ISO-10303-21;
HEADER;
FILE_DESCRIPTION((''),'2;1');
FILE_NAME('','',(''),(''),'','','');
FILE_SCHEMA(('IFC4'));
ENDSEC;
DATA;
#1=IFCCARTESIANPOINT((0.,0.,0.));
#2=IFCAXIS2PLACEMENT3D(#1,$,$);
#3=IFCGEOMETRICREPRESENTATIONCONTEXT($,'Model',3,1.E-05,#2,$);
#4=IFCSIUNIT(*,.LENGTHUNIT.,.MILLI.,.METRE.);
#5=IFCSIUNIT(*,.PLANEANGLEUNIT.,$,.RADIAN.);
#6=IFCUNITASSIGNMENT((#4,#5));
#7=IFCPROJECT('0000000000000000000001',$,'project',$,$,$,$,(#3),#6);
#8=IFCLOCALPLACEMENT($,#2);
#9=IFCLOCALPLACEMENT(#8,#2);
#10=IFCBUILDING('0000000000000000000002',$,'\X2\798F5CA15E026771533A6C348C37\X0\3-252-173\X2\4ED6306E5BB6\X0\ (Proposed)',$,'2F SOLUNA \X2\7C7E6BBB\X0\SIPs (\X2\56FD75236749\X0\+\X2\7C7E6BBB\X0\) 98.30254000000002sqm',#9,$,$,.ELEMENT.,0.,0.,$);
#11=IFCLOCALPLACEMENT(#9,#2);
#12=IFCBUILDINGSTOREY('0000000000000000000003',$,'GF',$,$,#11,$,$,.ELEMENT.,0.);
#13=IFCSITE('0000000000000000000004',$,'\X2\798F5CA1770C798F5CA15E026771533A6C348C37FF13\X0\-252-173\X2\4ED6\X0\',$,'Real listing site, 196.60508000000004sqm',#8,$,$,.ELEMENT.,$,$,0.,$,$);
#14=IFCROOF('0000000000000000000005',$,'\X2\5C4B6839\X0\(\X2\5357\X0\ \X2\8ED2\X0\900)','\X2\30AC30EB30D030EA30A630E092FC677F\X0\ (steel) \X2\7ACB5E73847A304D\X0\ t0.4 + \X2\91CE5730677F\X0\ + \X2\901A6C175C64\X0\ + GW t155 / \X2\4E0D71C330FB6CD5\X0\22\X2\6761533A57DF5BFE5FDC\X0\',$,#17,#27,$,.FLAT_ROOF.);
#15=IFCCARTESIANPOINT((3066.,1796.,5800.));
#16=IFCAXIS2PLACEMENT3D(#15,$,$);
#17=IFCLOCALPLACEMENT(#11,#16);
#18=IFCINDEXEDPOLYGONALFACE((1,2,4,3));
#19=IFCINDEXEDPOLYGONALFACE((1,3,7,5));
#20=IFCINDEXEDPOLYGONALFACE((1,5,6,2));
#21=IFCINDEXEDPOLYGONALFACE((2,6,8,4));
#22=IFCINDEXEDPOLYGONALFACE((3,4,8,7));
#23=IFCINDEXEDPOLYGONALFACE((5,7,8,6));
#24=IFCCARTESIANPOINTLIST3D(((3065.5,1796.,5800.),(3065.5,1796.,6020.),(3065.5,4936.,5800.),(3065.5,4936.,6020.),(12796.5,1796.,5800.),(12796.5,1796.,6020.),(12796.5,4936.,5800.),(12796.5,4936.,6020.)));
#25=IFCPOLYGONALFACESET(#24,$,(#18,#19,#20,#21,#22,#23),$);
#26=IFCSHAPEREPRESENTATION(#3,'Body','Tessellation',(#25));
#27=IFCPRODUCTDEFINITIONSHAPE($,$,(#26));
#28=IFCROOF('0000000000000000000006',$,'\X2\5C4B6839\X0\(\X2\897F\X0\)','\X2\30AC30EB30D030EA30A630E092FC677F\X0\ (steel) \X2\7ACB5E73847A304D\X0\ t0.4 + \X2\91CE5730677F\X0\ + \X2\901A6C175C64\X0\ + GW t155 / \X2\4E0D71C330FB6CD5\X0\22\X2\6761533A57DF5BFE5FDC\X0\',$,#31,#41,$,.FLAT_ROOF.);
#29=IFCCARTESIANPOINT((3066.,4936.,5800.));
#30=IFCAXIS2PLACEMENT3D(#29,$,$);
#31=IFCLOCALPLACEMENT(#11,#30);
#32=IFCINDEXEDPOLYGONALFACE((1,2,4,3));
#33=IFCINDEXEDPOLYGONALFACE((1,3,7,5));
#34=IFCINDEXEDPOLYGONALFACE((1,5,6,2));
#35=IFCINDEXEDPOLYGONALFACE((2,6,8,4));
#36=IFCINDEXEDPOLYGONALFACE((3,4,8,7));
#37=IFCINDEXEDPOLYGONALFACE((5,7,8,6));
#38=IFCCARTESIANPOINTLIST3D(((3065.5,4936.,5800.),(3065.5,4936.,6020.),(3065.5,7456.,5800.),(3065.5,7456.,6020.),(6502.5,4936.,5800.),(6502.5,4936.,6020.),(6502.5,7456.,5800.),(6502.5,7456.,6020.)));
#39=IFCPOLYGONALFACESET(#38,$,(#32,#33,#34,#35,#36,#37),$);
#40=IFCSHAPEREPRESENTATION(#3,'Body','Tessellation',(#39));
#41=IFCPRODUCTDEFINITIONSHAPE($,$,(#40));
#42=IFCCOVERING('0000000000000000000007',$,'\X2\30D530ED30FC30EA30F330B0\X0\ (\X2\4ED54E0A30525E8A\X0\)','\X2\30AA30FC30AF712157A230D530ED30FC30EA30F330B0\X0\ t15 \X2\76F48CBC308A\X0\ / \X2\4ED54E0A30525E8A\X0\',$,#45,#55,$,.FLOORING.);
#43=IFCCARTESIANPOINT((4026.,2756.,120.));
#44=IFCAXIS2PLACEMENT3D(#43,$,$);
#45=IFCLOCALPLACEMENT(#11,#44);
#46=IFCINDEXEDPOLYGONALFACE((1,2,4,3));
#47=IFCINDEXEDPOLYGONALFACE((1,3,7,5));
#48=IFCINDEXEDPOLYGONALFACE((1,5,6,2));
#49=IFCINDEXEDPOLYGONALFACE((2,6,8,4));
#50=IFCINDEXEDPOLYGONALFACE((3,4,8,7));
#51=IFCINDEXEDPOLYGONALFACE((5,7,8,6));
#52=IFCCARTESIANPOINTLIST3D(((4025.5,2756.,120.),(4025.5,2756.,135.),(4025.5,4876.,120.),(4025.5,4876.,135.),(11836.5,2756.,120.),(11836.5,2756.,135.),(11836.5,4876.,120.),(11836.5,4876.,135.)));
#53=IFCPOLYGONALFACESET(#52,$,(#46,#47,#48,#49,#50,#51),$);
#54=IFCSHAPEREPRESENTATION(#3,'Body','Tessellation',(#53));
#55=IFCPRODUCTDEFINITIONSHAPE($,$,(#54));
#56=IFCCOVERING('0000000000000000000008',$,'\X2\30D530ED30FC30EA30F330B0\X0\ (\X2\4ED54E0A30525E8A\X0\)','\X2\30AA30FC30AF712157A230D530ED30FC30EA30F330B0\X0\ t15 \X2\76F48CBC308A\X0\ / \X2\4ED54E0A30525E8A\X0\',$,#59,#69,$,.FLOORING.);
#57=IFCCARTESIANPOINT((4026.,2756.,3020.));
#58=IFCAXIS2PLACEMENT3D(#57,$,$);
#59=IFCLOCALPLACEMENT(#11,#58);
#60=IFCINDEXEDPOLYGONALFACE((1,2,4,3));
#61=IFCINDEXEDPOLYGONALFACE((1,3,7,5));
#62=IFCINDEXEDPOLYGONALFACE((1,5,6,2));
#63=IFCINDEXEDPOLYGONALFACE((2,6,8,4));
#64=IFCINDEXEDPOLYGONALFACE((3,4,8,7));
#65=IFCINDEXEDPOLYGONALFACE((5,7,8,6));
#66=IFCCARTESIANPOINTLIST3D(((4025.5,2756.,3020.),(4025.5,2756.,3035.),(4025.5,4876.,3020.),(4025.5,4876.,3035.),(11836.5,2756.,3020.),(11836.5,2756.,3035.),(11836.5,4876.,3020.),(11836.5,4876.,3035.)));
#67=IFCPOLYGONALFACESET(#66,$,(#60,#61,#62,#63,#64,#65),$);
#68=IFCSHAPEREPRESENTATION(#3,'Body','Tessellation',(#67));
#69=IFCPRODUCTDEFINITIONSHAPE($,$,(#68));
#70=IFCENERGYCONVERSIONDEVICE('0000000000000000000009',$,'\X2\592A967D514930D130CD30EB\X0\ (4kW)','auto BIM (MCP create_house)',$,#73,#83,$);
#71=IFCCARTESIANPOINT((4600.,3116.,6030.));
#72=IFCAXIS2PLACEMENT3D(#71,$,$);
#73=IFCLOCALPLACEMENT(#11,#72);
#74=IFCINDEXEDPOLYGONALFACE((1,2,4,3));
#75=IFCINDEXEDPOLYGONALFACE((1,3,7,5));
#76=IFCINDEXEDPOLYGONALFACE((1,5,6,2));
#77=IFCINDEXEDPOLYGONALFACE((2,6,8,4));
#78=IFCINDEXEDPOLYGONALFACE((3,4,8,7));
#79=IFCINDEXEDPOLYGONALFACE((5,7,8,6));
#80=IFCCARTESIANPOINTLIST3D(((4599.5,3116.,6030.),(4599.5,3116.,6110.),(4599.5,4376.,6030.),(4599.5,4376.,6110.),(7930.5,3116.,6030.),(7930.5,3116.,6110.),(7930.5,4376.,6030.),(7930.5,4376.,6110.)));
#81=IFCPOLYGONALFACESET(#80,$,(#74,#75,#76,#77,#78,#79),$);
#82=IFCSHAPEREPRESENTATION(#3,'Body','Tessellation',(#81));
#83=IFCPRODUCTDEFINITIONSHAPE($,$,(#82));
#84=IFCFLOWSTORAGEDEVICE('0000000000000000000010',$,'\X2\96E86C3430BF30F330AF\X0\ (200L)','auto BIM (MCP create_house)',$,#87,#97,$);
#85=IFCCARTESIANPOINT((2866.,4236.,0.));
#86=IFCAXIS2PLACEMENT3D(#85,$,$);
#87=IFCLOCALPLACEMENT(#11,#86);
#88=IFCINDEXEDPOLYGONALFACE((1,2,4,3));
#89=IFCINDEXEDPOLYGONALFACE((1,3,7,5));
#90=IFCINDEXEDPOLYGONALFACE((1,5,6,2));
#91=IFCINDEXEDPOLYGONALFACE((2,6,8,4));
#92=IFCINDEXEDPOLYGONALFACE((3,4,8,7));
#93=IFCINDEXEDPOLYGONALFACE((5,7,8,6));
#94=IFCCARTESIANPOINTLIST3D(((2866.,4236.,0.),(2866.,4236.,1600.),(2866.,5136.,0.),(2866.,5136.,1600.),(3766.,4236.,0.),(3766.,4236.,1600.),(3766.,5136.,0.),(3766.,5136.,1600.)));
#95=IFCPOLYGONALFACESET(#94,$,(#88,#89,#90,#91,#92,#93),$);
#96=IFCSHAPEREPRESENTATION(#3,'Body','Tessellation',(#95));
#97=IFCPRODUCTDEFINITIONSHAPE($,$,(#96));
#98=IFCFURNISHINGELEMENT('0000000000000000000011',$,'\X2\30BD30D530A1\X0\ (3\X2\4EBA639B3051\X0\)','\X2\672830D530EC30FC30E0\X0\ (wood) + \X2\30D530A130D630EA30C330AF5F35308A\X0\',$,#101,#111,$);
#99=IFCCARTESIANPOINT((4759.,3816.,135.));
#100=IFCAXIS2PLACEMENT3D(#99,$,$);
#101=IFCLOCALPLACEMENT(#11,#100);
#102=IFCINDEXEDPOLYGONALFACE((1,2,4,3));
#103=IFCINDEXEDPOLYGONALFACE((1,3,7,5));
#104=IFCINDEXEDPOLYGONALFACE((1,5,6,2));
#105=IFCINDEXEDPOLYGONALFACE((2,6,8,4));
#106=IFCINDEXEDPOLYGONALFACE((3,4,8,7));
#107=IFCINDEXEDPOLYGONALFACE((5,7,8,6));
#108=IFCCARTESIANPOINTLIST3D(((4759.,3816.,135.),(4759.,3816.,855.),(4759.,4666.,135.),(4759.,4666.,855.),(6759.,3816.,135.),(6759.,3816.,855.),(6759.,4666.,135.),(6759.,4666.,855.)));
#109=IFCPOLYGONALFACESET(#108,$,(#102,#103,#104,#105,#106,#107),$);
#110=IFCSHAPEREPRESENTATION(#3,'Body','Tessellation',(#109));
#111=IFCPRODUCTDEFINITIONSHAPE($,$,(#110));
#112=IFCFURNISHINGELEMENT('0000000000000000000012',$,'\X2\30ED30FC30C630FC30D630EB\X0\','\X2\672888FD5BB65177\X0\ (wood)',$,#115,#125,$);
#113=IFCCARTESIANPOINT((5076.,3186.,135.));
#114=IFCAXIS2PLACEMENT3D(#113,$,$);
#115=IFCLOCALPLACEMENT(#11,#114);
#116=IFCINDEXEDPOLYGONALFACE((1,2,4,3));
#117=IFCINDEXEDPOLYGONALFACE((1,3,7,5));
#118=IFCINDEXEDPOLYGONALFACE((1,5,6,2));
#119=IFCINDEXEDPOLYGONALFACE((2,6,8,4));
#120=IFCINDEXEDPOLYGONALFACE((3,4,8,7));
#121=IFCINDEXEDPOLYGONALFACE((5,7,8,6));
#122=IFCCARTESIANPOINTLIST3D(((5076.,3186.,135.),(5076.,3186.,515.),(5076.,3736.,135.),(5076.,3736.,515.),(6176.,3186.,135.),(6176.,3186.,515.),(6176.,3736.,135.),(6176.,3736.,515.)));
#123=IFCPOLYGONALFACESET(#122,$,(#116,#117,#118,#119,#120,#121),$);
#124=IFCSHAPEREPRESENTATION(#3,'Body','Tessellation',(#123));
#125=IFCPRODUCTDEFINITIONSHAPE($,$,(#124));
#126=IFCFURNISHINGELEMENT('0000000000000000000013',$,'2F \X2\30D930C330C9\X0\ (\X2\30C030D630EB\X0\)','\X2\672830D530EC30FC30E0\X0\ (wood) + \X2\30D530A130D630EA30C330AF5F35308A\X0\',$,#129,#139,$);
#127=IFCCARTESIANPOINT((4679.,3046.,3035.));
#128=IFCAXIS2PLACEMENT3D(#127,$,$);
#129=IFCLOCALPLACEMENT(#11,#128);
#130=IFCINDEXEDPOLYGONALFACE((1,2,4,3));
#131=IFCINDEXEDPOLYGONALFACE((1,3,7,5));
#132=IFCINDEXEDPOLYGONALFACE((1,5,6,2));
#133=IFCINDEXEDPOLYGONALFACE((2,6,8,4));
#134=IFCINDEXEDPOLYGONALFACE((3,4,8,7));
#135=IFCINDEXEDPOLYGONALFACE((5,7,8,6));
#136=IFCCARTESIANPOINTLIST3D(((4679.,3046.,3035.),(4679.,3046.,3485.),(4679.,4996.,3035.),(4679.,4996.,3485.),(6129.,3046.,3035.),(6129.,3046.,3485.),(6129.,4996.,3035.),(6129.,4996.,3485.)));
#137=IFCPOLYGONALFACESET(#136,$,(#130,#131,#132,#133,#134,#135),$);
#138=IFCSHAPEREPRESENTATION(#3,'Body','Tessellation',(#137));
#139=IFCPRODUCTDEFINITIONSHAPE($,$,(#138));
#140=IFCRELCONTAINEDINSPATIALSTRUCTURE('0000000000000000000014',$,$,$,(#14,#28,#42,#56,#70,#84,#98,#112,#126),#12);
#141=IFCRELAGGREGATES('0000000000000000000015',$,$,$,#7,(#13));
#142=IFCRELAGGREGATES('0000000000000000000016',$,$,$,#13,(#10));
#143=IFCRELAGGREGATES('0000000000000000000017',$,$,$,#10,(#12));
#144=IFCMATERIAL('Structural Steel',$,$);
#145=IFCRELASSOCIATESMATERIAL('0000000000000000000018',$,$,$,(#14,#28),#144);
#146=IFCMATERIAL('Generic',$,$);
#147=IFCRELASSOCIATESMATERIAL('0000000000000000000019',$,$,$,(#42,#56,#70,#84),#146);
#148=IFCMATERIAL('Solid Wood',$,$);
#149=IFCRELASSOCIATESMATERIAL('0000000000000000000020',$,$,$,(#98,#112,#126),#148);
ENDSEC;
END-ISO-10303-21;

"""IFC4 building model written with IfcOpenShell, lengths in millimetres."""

from ifc_helpers import new_model, si_unit, frame, frame_2d, origin, place, context, project, spatial, rectangle, extrude, material, element, save


model = new_model("IFC4")

# Units and contexts
model_context = context("Model", 3, precision=1e-05, world=origin())
ifc_project = project(units=[si_unit("LENGTHUNIT", "METRE", prefix="MILLI"), si_unit("PLANEANGLEUNIT", "RADIAN")], contexts=[model_context])

# Site, building, storey
site_placement = place(None, origin())
site = spatial("IfcSite", under=ifc_project, at=site_placement, Name="福岡県福岡市東区水谷３-252-173他", ObjectType="Real listing site, 196.60508000000004sqm", CompositionType="ELEMENT", RefElevation=0.0)
building_placement = place(site_placement, origin())
building = spatial("IfcBuilding", under=site, at=building_placement, Name="福岡市東区水谷3-252-173他の家 (Proposed)", ObjectType="2F SOLUNA 籾殻SIPs (国産杉+籾殻) 98.30254000000002sqm", CompositionType="ELEMENT", ElevationOfRefHeight=0.0, ElevationOfTerrain=0.0)
storey_placement = place(building_placement, origin())
storey = spatial("IfcBuildingStorey", under=building, at=storey_placement, Name="GF", CompositionType="ELEMENT", Elevation=0.0)

# Shared definitions
ifc_material_1 = material(Name="Solid Wood")

# Roofs
ifc_material_2 = material(Name="Structural Steel")
roof_1_placement = place(storey_placement, frame((3066.0, 1796.0, 5800.0)))
element("IfcRoof", 1, at=roof_1_placement, inside=storey, material=ifc_material_2, Name="屋根(南 軒900)", Description="ガルバリウム鋼板 (steel) 立平葺き t0.4 + 野地板 + 通気層 + GW t155 / 不燃・法22条区域対応", PredefinedType="FLAT_ROOF", context=model_context, shape_type="SweptSolid", body=[
    extrude(rectangle(XDim=9731.0, YDim=3140.0, at=frame_2d((4865.0, 1570.0))), frame((3066.0, 1796.0, 5800.0)), (0.0, 0.0, 1.0), 220.0),
])
roof_2_placement = place(storey_placement, frame((3066.0, 4936.0, 5800.0)))
element("IfcRoof", 2, at=roof_2_placement, inside=storey, material=ifc_material_2, Name="屋根(西)", Description="ガルバリウム鋼板 (steel) 立平葺き t0.4 + 野地板 + 通気層 + GW t155 / 不燃・法22条区域対応", PredefinedType="FLAT_ROOF", context=model_context, shape_type="SweptSolid", body=[
    extrude(rectangle(XDim=3437.0, YDim=2520.0, at=frame_2d((1718.0, 1260.0))), frame((3066.0, 4936.0, 5800.0)), (0.0, 0.0, 1.0), 220.0),
])

# Coverings
ifc_material_3 = material(Name="Generic")
covering_1_placement = place(storey_placement, frame((4026.0, 2756.0, 120.0)))
element("IfcCovering", 3, at=covering_1_placement, inside=storey, material=ifc_material_3, Name="フローリング (仕上げ床)", Description="オーク無垢フローリング t15 直貼り / 仕上げ床", PredefinedType="FLOORING", context=model_context, shape_type="SweptSolid", body=[
    extrude(rectangle(XDim=7811.0, YDim=2120.0, at=frame_2d((3905.0, 1060.0))), frame((4026.0, 2756.0, 120.0)), (0.0, 0.0, 1.0), 15.0),
])
covering_2_placement = place(storey_placement, frame((4026.0, 2756.0, 3020.0)))
element("IfcCovering", 4, at=covering_2_placement, inside=storey, material=ifc_material_3, Name="フローリング (仕上げ床)", Description="オーク無垢フローリング t15 直貼り / 仕上げ床", PredefinedType="FLOORING", context=model_context, shape_type="SweptSolid", body=[
    extrude(rectangle(XDim=7811.0, YDim=2120.0, at=frame_2d((3905.0, 1060.0))), frame((4026.0, 2756.0, 3020.0)), (0.0, 0.0, 1.0), 15.0),
])

# Energy conversion device
energy_conversion_device_placement = place(storey_placement, frame((4600.0, 3116.0, 6030.0)))
element("IfcEnergyConversionDevice", 5, at=energy_conversion_device_placement, inside=storey, material=ifc_material_3, Name="太陽光パネル (4kW)", Description="auto BIM (MCP create_house)", context=model_context, shape_type="SweptSolid", body=[
    extrude(rectangle(XDim=3331.0, YDim=1260.0, at=frame_2d((1665.0, 630.0))), frame((4600.0, 3116.0, 6030.0)), (0.0, 0.0, 1.0), 80.0),
])

# Flow storage device
flow_storage_device_placement = place(storey_placement, frame((2866.0, 4236.0, 0.0)))
element("IfcFlowStorageDevice", 6, at=flow_storage_device_placement, inside=storey, material=ifc_material_3, Name="雨水タンク (200L)", Description="auto BIM (MCP create_house)", context=model_context, shape_type="SweptSolid", body=[
    extrude(rectangle(XDim=900.0, YDim=900.0, at=frame_2d((450.0, 450.0))), frame((2866.0, 4236.0, 0.0)), (0.0, 0.0, 1.0), 1600.0),
])

# Furnishing elements
furnishing_1_placement = place(storey_placement, frame((4759.0, 3816.0, 135.0)))
element("IfcFurnishingElement", 7, at=furnishing_1_placement, inside=storey, material=ifc_material_1, Name="ソファ (3人掛け)", Description="木フレーム (wood) + ファブリック張り", context=model_context, shape_type="SweptSolid", body=[
    extrude(rectangle(XDim=2000.0, YDim=850.0, at=frame_2d((1000.0, 425.0))), frame((4759.0, 3816.0, 135.0)), (0.0, 0.0, 1.0), 720.0),
])
furnishing_2_placement = place(storey_placement, frame((5076.0, 3186.0, 135.0)))
element("IfcFurnishingElement", 8, at=furnishing_2_placement, inside=storey, material=ifc_material_1, Name="ローテーブル", Description="木製家具 (wood)", context=model_context, shape_type="SweptSolid", body=[
    extrude(rectangle(XDim=1100.0, YDim=550.0, at=frame_2d((550.0, 275.0))), frame((5076.0, 3186.0, 135.0)), (0.0, 0.0, 1.0), 380.0),
])
furnishing_3_placement = place(storey_placement, frame((4679.0, 3046.0, 3035.0)))
element("IfcFurnishingElement", 9, at=furnishing_3_placement, inside=storey, material=ifc_material_1, Name="2F ベッド (ダブル)", Description="木フレーム (wood) + ファブリック張り", context=model_context, shape_type="SweptSolid", body=[
    extrude(rectangle(XDim=1450.0, YDim=1950.0, at=frame_2d((725.0, 975.0))), frame((4679.0, 3046.0, 3035.0)), (0.0, 0.0, 1.0), 450.0),
])

save(model, "model.ifc")
